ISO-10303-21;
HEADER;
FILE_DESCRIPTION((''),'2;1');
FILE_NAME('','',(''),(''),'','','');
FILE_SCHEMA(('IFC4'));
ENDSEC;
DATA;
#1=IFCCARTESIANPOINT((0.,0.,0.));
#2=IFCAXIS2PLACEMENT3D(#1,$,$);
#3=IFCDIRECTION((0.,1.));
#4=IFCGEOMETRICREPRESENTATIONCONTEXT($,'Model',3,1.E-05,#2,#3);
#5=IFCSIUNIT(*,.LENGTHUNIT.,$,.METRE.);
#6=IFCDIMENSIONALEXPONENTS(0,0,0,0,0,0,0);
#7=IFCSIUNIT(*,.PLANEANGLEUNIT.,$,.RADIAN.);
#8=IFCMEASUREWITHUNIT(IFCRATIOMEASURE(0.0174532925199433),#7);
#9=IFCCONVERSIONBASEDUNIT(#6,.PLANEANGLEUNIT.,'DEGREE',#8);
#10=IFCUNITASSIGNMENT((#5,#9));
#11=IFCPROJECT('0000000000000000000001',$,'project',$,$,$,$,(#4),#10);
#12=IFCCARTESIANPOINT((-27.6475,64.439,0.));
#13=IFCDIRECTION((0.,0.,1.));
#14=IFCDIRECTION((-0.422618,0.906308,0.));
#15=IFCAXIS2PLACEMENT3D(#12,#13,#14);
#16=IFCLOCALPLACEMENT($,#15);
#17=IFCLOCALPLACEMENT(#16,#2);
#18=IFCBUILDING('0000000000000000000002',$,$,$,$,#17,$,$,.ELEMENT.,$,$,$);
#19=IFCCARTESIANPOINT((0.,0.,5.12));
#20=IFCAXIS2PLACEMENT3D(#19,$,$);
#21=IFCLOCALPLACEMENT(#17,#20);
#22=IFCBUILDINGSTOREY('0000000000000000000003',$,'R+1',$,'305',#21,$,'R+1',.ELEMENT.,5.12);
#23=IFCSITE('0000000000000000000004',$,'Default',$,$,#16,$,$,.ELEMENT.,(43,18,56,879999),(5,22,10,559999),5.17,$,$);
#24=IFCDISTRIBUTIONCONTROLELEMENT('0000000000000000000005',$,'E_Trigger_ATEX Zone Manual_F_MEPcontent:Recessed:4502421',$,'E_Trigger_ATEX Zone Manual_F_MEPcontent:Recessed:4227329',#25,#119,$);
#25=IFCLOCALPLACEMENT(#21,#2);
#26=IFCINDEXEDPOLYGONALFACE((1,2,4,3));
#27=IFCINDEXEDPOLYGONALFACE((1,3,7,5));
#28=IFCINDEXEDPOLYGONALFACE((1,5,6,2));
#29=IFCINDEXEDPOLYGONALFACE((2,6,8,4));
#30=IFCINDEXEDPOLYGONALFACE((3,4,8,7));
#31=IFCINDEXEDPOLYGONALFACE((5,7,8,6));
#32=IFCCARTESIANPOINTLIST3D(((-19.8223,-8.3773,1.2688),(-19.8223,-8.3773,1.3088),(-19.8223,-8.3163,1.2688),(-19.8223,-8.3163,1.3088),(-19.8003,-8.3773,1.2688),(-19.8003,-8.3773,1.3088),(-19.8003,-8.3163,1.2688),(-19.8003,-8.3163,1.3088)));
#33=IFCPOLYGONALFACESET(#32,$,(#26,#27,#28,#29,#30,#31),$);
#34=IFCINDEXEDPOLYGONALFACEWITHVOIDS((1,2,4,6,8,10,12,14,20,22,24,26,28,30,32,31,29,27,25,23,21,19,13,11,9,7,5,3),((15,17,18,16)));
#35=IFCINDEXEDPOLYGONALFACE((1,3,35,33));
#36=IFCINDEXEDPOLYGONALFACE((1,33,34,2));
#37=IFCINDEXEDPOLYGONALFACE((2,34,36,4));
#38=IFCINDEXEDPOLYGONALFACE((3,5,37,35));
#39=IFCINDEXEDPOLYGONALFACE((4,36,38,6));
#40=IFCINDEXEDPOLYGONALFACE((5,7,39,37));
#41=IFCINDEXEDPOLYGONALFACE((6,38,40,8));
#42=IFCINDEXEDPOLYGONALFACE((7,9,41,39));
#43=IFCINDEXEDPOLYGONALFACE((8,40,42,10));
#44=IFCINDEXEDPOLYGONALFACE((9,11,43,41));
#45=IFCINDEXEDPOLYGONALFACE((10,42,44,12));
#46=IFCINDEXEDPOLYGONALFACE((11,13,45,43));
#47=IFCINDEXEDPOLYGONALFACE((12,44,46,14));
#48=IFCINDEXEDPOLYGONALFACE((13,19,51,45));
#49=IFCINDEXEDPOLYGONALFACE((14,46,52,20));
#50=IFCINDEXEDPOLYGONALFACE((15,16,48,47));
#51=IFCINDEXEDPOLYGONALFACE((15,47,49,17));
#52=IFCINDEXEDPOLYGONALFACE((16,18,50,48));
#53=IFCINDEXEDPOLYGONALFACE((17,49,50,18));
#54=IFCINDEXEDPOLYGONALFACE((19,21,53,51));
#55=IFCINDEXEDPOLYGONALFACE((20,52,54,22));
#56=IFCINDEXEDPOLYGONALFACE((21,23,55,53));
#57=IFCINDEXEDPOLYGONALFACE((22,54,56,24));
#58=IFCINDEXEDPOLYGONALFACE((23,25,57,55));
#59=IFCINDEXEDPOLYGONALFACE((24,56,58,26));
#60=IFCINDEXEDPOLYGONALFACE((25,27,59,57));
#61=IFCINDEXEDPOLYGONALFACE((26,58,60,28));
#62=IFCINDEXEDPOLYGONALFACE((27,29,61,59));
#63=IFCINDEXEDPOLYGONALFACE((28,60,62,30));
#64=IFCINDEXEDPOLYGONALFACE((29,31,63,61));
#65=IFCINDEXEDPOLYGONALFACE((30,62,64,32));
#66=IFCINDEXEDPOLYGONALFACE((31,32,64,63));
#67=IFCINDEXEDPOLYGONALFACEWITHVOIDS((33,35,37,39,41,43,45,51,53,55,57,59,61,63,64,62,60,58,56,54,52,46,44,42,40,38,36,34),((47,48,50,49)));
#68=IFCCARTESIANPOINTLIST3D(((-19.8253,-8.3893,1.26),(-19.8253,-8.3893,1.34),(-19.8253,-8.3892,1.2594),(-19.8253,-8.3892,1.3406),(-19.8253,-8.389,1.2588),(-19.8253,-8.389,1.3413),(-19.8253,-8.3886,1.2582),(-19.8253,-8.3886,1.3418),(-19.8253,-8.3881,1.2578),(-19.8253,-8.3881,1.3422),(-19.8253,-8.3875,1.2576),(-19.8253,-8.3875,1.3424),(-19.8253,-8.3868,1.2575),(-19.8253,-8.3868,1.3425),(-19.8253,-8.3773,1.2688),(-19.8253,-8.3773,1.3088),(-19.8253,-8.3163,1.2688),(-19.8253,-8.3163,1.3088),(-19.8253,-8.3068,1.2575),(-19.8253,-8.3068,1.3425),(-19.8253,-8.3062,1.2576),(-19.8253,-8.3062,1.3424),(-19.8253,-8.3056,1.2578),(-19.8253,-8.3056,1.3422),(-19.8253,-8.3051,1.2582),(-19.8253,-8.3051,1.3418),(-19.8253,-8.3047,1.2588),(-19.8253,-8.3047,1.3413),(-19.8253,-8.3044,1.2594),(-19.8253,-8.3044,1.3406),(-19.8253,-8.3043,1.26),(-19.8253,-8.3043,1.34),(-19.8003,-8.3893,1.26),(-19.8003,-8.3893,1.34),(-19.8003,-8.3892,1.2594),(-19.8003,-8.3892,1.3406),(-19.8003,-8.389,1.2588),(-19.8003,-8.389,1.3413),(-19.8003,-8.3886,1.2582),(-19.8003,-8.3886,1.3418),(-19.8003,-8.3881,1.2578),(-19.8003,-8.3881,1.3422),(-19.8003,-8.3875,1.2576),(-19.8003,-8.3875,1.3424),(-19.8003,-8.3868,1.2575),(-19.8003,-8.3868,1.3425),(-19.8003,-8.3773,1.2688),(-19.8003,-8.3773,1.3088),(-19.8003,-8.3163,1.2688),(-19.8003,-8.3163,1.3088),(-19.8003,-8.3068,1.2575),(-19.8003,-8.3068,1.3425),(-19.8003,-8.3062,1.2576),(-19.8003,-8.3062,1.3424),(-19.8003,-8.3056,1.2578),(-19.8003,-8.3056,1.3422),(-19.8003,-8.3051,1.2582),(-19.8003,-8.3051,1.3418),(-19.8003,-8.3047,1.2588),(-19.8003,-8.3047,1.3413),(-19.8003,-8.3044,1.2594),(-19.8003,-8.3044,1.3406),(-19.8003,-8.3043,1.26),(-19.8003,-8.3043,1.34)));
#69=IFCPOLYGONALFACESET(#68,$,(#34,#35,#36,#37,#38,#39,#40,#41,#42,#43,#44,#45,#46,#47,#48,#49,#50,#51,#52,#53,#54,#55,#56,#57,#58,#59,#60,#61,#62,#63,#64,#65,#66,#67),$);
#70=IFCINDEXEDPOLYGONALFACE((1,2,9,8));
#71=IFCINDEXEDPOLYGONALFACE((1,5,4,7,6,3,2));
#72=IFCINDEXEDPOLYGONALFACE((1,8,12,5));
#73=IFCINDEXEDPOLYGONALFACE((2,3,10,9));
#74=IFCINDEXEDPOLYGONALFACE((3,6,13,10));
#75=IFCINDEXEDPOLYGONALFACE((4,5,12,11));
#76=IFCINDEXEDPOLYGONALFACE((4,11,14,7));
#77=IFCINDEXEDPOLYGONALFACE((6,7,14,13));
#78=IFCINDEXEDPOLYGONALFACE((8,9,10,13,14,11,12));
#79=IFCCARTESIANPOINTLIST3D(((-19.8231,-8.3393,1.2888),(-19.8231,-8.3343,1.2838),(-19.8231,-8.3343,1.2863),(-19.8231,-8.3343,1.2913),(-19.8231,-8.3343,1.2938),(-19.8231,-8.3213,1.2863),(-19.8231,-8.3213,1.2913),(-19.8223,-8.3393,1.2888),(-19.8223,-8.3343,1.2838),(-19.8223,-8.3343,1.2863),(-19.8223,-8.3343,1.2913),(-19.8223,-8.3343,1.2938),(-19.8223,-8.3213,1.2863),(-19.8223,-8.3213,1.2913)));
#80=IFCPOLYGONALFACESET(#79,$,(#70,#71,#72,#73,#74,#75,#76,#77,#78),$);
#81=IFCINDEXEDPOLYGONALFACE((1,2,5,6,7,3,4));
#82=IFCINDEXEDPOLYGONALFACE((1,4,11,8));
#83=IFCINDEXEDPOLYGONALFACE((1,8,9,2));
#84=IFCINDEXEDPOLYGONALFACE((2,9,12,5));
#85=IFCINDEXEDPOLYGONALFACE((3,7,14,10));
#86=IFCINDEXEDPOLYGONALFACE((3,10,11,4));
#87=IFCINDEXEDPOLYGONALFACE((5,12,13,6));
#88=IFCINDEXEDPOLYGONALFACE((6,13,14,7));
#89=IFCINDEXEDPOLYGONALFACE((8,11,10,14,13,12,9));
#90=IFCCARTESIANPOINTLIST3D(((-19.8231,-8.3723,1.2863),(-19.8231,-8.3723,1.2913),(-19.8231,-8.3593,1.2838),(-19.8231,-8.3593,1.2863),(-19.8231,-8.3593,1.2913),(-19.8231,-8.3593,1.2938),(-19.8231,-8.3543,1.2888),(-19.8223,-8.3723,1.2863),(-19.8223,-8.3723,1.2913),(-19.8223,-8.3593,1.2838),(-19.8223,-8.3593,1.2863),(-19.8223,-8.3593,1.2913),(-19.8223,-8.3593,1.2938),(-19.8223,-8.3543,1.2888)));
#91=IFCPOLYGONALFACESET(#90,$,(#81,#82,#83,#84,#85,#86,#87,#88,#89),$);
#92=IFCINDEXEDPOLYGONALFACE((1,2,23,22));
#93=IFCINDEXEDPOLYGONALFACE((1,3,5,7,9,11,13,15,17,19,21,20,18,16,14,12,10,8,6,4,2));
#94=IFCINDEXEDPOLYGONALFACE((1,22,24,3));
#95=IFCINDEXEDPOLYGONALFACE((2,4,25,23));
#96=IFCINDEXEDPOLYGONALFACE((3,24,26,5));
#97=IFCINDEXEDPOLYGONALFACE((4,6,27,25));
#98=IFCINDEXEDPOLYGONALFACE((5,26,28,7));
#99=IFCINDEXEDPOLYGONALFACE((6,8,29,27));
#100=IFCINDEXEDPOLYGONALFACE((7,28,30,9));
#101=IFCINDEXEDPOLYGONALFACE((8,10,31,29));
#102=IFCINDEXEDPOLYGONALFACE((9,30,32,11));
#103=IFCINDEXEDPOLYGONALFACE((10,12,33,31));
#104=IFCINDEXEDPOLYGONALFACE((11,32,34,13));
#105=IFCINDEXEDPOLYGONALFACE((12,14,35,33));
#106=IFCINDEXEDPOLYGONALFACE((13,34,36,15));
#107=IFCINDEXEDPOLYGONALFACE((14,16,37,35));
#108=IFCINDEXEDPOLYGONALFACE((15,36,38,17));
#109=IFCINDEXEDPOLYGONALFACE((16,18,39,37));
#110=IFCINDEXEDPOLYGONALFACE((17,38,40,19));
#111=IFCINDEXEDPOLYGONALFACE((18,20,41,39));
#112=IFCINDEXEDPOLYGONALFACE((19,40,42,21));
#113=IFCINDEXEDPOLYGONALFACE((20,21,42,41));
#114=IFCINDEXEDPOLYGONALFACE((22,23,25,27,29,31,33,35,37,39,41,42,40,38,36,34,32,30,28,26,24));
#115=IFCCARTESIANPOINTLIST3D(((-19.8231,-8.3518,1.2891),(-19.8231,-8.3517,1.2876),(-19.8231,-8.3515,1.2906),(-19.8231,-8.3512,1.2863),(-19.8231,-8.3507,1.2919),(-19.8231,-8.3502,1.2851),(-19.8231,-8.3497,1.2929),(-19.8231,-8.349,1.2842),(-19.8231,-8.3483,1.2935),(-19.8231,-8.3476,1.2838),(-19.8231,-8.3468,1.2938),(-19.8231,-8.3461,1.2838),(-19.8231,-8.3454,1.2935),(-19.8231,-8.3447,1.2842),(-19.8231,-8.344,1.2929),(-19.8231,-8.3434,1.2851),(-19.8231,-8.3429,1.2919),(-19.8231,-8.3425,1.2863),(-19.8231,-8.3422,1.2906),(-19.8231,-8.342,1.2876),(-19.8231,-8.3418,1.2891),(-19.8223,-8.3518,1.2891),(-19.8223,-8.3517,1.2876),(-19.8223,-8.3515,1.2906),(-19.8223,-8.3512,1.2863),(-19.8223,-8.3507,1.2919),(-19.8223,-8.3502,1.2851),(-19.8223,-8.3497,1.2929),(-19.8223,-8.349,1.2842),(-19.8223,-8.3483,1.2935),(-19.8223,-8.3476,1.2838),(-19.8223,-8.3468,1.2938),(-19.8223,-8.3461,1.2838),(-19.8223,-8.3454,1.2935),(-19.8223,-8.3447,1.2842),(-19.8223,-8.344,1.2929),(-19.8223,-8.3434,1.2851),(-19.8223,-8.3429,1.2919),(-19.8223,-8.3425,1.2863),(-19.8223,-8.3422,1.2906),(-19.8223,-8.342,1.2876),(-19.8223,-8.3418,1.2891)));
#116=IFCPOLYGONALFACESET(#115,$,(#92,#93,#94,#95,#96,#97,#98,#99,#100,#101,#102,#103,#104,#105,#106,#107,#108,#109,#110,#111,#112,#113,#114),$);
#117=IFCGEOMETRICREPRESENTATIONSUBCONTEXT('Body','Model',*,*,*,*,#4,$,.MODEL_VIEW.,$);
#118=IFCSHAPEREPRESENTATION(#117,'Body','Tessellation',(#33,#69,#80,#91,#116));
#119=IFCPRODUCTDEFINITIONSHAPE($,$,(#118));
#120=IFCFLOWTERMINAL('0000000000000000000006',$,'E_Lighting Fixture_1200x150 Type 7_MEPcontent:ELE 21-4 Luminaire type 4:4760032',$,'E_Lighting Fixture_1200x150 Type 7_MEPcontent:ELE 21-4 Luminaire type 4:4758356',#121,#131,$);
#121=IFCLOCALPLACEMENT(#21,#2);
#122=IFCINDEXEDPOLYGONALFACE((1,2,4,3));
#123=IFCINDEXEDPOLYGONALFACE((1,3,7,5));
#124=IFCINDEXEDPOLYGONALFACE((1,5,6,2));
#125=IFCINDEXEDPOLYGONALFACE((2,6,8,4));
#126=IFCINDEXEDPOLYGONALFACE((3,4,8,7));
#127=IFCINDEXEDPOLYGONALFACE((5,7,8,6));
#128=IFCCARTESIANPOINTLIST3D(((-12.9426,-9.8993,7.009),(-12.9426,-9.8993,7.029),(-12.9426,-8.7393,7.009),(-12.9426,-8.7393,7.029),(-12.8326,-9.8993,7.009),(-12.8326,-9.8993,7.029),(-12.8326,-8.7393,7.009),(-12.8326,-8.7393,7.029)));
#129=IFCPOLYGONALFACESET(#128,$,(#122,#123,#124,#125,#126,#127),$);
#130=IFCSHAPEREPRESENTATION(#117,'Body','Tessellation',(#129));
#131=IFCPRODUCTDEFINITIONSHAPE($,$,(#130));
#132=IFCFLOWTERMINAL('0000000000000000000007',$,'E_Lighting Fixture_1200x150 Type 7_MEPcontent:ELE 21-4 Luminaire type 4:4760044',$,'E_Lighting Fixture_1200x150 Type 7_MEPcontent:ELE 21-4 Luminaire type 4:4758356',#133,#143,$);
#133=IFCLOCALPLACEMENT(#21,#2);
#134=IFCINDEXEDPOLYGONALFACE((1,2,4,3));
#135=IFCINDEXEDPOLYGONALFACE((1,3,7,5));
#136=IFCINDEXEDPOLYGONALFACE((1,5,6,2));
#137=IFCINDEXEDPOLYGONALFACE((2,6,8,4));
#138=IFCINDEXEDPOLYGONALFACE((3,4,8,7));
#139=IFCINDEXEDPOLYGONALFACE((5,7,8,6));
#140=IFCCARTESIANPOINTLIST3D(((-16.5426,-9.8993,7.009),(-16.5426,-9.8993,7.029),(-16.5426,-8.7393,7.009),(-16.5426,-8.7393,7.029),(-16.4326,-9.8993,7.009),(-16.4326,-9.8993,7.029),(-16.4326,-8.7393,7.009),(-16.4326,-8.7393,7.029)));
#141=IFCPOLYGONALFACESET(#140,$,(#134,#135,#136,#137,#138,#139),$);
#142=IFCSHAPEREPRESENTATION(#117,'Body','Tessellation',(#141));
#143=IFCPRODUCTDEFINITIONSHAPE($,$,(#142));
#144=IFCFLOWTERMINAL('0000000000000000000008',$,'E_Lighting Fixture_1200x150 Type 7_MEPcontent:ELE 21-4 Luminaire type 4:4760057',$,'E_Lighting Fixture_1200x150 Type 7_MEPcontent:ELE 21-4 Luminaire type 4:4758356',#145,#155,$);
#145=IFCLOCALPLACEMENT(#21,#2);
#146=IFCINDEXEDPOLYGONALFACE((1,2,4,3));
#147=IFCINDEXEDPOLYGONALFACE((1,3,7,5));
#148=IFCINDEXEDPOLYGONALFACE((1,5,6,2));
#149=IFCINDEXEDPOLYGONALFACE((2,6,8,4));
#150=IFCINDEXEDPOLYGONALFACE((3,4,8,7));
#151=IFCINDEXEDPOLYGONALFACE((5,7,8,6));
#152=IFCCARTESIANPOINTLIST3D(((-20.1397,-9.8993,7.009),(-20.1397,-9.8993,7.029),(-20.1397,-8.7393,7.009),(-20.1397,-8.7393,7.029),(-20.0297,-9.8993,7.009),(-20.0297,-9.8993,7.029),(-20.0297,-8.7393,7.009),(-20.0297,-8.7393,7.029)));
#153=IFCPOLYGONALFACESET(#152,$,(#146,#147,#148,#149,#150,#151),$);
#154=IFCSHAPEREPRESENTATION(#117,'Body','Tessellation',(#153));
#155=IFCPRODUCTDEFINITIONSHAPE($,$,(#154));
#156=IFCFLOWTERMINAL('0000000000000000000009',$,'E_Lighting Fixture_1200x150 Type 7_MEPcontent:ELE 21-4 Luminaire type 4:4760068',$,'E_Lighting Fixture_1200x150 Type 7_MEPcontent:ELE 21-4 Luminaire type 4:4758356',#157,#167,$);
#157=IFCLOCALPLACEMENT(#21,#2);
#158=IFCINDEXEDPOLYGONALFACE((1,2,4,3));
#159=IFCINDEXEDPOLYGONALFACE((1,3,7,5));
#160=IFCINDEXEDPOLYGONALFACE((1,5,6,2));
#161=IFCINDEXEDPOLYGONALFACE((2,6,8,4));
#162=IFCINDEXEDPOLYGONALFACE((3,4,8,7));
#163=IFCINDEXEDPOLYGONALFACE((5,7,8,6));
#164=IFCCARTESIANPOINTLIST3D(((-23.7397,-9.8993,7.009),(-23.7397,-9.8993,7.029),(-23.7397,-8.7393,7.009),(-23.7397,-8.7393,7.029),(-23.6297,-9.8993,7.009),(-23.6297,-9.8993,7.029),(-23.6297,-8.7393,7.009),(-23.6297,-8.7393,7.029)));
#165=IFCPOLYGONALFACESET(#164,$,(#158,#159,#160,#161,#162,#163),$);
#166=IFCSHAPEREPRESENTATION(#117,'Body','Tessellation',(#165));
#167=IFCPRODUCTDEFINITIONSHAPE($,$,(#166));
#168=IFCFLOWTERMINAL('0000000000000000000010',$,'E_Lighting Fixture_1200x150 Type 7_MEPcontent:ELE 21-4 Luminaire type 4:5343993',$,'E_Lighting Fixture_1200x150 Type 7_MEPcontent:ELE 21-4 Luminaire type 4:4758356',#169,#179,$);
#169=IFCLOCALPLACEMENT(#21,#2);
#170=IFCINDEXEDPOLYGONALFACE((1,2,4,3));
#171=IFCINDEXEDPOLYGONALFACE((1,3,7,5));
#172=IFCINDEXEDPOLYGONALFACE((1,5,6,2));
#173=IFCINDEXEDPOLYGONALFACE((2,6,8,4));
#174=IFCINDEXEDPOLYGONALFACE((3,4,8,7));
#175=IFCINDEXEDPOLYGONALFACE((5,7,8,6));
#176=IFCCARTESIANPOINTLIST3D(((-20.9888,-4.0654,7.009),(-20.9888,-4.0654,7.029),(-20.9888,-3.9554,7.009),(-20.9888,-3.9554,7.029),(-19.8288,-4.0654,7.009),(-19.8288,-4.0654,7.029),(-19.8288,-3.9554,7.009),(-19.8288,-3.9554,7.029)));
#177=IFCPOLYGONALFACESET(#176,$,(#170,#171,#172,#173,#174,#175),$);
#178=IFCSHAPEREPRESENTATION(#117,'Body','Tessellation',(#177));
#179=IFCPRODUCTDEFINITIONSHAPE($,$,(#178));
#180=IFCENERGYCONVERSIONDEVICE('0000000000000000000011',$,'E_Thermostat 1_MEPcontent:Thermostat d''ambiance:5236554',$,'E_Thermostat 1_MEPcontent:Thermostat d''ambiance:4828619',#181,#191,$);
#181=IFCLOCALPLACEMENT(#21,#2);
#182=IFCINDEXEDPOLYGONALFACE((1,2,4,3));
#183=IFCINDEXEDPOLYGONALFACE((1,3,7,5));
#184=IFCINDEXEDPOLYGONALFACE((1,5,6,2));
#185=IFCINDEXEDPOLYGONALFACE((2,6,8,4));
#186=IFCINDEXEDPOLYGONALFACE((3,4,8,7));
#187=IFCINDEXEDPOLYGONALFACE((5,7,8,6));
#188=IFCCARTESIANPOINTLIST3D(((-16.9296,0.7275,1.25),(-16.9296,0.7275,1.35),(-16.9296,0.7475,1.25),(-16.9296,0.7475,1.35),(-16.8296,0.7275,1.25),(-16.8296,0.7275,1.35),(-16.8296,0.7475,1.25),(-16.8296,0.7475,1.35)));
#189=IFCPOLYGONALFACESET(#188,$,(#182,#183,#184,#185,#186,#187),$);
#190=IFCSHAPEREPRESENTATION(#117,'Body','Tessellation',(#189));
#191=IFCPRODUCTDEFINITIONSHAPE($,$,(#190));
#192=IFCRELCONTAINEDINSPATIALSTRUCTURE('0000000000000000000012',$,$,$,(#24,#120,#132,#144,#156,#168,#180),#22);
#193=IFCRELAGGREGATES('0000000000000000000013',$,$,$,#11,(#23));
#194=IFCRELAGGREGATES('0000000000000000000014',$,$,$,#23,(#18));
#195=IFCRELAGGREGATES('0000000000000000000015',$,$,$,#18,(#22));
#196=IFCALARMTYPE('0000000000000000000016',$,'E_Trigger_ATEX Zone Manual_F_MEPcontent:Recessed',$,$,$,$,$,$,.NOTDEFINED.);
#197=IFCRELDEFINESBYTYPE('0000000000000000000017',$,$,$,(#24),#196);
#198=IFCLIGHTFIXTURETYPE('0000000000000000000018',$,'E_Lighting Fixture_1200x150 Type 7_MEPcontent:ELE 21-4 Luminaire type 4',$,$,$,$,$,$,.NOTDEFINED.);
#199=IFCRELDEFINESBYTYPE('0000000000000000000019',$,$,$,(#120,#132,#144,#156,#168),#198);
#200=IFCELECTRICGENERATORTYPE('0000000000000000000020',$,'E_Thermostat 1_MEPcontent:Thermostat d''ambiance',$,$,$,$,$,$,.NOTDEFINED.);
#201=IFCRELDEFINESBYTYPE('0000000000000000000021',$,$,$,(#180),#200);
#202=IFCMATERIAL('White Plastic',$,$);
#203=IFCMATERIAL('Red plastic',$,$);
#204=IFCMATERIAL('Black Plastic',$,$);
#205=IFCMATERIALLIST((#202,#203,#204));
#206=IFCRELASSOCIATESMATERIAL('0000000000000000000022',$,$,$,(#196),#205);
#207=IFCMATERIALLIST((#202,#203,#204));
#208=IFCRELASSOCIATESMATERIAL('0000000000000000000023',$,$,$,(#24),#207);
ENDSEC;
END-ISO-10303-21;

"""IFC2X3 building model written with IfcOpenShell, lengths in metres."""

from ifc_helpers import new_model, entity, si_unit, converted_unit, direction, frame, frame_2d, origin, origin_2d_with_axis, place, context, subcontext, project, spatial, polyline, circle_curve, parameter, trimmed, segment, composite_curve, rectangle, circle, outline, extrude, source, transform, mapped, material, material_list, type_object, type_shapes, element, save


model = new_model("IFC2X3")

# Units and contexts
model_context = context("Model", 3, precision=1e-05, world=origin(), true_north=direction((0.0, 1.0)))
body_context = subcontext(model_context, "Body", "Model", "MODEL_VIEW")
ifc_project = project(units=[si_unit("LENGTHUNIT", "METRE"), converted_unit("PLANEANGLEUNIT", "DEGREE", entity("IfcRatioMeasure", 0.0174532925199433), si_unit("PLANEANGLEUNIT", "RADIAN"), dimensions=[0, 0, 0, 0, 0, 0, 0])], contexts=[model_context])

# Site, building, storey
site_placement = place(None, frame((-27.6475, 64.439, 0.0), z_axis=(0.0, 0.0, 1.0), x_axis=(-0.422618, 0.906308, 0.0)))
site = spatial("IfcSite", under=ifc_project, at=site_placement, Name="Default", CompositionType="ELEMENT", RefLatitude=(43, 18, 56, 879999), RefLongitude=(5, 22, 10, 559999), RefElevation=5.17)
building_placement = place(site_placement, origin())
building = spatial("IfcBuilding", under=site, at=building_placement, CompositionType="ELEMENT")
storey_placement = place(building_placement, frame((0.0, 0.0, 5.12)))
storey = spatial("IfcBuildingStorey", under=building, at=storey_placement, Name="R+1", ObjectType="305", LongName="R+1", CompositionType="ELEMENT", Elevation=5.12)

# Distribution control element
ifc_material_1 = material(Name="White Plastic")
ifc_material_2 = material(Name="Red plastic")
ifc_material_3 = material(Name="Black Plastic")
ifc_material_list_1 = material_list([ifc_material_1, ifc_material_2, ifc_material_3])
alarm_type_1 = type_object("IfcAlarmType", Name="E_Trigger_ATEX Zone Manual_F_MEPcontent:Recessed", PredefinedType="NOTDEFINED", material=ifc_material_list_1)
shared_shape_1 = source(origin(), body_context, "Body", "SweptSolid", [
    extrude(rectangle(XDim=0.061, YDim=0.04, at=origin_2d_with_axis()), frame((0.0, -0.0112, 0.0), z_axis=(0.0, 0.0, 1.0), x_axis=(-1.0, 0.0, 0.0)), (0.0, 0.0, 1.0), 0.022),
    extrude(outline(composite_curve([segment(polyline([(-0.04, -0.0425), (0.04, -0.0425)]), True, "CONTINUOUS"), segment(trimmed(circle_curve(frame_2d((0.04, -0.04), x_axis=(-1.0, 0.0)), 0.0025), [parameter(90.0)], [parameter(180.0)], True, "PARAMETER"), True, "CONTINUOUS"), segment(polyline([(0.0425, -0.04), (0.0425, 0.04)]), True, "CONTINUOUS"), segment(trimmed(circle_curve(frame_2d((0.04, 0.04), x_axis=(-1.0, 0.0)), 0.0025), [parameter(180.0)], [parameter(270.0)], True, "PARAMETER"), True, "CONTINUOUS"), segment(polyline([(0.04, 0.0425), (-0.04, 0.0425)]), True, "CONTINUOUS"), segment(trimmed(circle_curve(frame_2d((-0.04, 0.04), x_axis=(-1.0, 0.0)), 0.0025), [parameter(270.0)], [parameter(0.0)], True, "PARAMETER"), True, "CONTINUOUS"), segment(polyline([(-0.0425, 0.04), (-0.0425, -0.04)]), True, "CONTINUOUS"), segment(trimmed(circle_curve(frame_2d((-0.04, -0.04), x_axis=(-1.0, 0.0)), 0.0025), [parameter(360.0)], [parameter(90.0)], True, "PARAMETER"), True, "CONTINUOUS")], self_intersect=False), holes=[polyline([(-0.0305, -0.0088), (-0.0305, 0.0312), (0.0305, 0.0312), (0.0305, -0.0088), (-0.0305, -0.0088)])]), frame((0.0, 0.0, 0.0), z_axis=(0.0, 0.0, 1.0), x_axis=(-1.0, 0.0, 0.0)), (0.0, 0.0, 1.0), 0.025),
    extrude(outline(polyline([(-0.01, 0.0025), (-0.01, -0.0025), (0.003, -0.0025), (0.003, -0.005), (0.008, 0.0), (0.003, 0.005), (0.003, 0.0025), (-0.01, 0.0025)])), frame((-0.0155, -0.0112, 0.022), z_axis=(0.0, 0.0, -1.0), x_axis=(1.0, 0.0, 0.0)), (0.0, 0.0, -1.0), 0.0008),
    extrude(outline(polyline([(-0.0014, -0.0057), (0.0057, -0.0057), (0.0057, 0.0014), (0.0039, -0.0004), (-0.0053, 0.0088), (-0.0088, 0.0053), (0.0004, -0.0039), (-0.0014, -0.0057)])), frame((0.0155, -0.0112, 0.022), z_axis=(0.0, 0.0, 1.0), x_axis=(-0.707107, -0.707107, 0.0)), (0.0, 0.0, 1.0), 0.0008),
    extrude(circle(Radius=0.005, at=frame_2d((0.0, 0.0), x_axis=(1.0, 0.0))), frame((0.0, -0.0112, 0.022), z_axis=(0.0, 0.0, 1.0), x_axis=(0.0, 1.0, 0.0)), (0.0, 0.0, 1.0), 0.0008),
])
type_shapes(alarm_type_1, [shared_shape_1])
ifc_material_list_2 = material_list([ifc_material_1, ifc_material_2, ifc_material_3])
distribution_control_element_1_placement = place(storey_placement, frame((-19.8003, -8.3468, 1.3), z_axis=(-1.0, 0.0, 0.0), x_axis=(0.0, -1.0, 0.0)))
element("IfcDistributionControlElement", 1, at=distribution_control_element_1_placement, inside=storey, type_object=alarm_type_1, material=ifc_material_list_2, Name="E_Trigger_ATEX Zone Manual_F_MEPcontent:Recessed:4502421", ObjectType="E_Trigger_ATEX Zone Manual_F_MEPcontent:Recessed:4227329", context=body_context, shape_type="MappedRepresentation", body=[
    mapped(shared_shape_1, transform((0.0, 0.0, 0.0), scale=1.0)),
])

# Flow terminals
light_fixture_type_1 = type_object("IfcLightFixtureType", Name="E_Lighting Fixture_1200x150 Type 7_MEPcontent:ELE 21-4 Luminaire type 4", PredefinedType="NOTDEFINED")
shared_shape_2 = source(origin(), body_context, "Body", "SweptSolid", [
    extrude(rectangle(XDim=0.11, YDim=1.16, at=origin_2d_with_axis()), frame((0.0, 0.0, 0.0), z_axis=(0.0, 0.0, 1.0), x_axis=(0.0, -1.0, 0.0)), (0.0, 0.0, 1.0), 0.02),
])
type_shapes(light_fixture_type_1, [shared_shape_2])
for number, where, z_axis, x_axis, name in (
    (2, (-12.8876, -9.3193, 7.009), (0.0, 0.0, 1.0), (0.0, -1.0, 0.0), "E_Lighting Fixture_1200x150 Type 7_MEPcontent:ELE 21-4 Luminaire type 4:4760032"),
    (3, (-16.4876, -9.3193, 7.009), (0.0, 0.0, 1.0), (0.0, -1.0, 0.0), "E_Lighting Fixture_1200x150 Type 7_MEPcontent:ELE 21-4 Luminaire type 4:4760044"),
    (4, (-20.0847, -9.3193, 7.009), (0.0, 0.0, 1.0), (0.0, -1.0, 0.0), "E_Lighting Fixture_1200x150 Type 7_MEPcontent:ELE 21-4 Luminaire type 4:4760057"),
    (5, (-23.6847, -9.3193, 7.009), (0.0, 0.0, 1.0), (0.0, -1.0, 0.0), "E_Lighting Fixture_1200x150 Type 7_MEPcontent:ELE 21-4 Luminaire type 4:4760068"),
):
    element("IfcFlowTerminal", number, at=place(storey_placement, frame(where, z_axis=z_axis, x_axis=x_axis)), inside=storey, type_object=light_fixture_type_1, Name=name, ObjectType="E_Lighting Fixture_1200x150 Type 7_MEPcontent:ELE 21-4 Luminaire type 4:4758356", context=body_context, shape_type="MappedRepresentation", body=[
        mapped(shared_shape_2, transform((0.0, 0.0, 0.0), scale=1.0)),
    ])
flow_terminal_1_placement = place(storey_placement, frame((-20.4088, -4.0104, 7.009)))
element("IfcFlowTerminal", 6, at=flow_terminal_1_placement, inside=storey, type_object=light_fixture_type_1, Name="E_Lighting Fixture_1200x150 Type 7_MEPcontent:ELE 21-4 Luminaire type 4:5343993", ObjectType="E_Lighting Fixture_1200x150 Type 7_MEPcontent:ELE 21-4 Luminaire type 4:4758356", context=body_context, shape_type="MappedRepresentation", body=[
    mapped(shared_shape_2, transform((0.0, 0.0, 0.0), scale=1.0)),
])

# Energy conversion device
electric_generator_type_1 = type_object("IfcElectricGeneratorType", Name="E_Thermostat 1_MEPcontent:Thermostat d'ambiance", PredefinedType="NOTDEFINED")
shared_shape_3 = source(origin(), body_context, "Body", "SweptSolid", [
    extrude(rectangle(XDim=0.02, YDim=0.1, at=frame_2d((0.0, 0.0), x_axis=(1.0, 0.0))), frame((0.0, 0.01, -0.05), z_axis=(0.0, 0.0, 1.0), x_axis=(0.0, -1.0, 0.0)), (0.0, 0.0, 1.0), 0.1),
])
type_shapes(electric_generator_type_1, [shared_shape_3])
energy_conversion_device_1_placement = place(storey_placement, frame((-16.8796, 0.7275, 1.3)))
element("IfcEnergyConversionDevice", 7, at=energy_conversion_device_1_placement, inside=storey, type_object=electric_generator_type_1, Name="E_Thermostat 1_MEPcontent:Thermostat d'ambiance:5236554", ObjectType="E_Thermostat 1_MEPcontent:Thermostat d'ambiance:4828619", context=body_context, shape_type="MappedRepresentation", body=[
    mapped(shared_shape_3, transform((0.0, 0.0, 0.0), scale=1.0)),
])

save(model, "model.ifc")
